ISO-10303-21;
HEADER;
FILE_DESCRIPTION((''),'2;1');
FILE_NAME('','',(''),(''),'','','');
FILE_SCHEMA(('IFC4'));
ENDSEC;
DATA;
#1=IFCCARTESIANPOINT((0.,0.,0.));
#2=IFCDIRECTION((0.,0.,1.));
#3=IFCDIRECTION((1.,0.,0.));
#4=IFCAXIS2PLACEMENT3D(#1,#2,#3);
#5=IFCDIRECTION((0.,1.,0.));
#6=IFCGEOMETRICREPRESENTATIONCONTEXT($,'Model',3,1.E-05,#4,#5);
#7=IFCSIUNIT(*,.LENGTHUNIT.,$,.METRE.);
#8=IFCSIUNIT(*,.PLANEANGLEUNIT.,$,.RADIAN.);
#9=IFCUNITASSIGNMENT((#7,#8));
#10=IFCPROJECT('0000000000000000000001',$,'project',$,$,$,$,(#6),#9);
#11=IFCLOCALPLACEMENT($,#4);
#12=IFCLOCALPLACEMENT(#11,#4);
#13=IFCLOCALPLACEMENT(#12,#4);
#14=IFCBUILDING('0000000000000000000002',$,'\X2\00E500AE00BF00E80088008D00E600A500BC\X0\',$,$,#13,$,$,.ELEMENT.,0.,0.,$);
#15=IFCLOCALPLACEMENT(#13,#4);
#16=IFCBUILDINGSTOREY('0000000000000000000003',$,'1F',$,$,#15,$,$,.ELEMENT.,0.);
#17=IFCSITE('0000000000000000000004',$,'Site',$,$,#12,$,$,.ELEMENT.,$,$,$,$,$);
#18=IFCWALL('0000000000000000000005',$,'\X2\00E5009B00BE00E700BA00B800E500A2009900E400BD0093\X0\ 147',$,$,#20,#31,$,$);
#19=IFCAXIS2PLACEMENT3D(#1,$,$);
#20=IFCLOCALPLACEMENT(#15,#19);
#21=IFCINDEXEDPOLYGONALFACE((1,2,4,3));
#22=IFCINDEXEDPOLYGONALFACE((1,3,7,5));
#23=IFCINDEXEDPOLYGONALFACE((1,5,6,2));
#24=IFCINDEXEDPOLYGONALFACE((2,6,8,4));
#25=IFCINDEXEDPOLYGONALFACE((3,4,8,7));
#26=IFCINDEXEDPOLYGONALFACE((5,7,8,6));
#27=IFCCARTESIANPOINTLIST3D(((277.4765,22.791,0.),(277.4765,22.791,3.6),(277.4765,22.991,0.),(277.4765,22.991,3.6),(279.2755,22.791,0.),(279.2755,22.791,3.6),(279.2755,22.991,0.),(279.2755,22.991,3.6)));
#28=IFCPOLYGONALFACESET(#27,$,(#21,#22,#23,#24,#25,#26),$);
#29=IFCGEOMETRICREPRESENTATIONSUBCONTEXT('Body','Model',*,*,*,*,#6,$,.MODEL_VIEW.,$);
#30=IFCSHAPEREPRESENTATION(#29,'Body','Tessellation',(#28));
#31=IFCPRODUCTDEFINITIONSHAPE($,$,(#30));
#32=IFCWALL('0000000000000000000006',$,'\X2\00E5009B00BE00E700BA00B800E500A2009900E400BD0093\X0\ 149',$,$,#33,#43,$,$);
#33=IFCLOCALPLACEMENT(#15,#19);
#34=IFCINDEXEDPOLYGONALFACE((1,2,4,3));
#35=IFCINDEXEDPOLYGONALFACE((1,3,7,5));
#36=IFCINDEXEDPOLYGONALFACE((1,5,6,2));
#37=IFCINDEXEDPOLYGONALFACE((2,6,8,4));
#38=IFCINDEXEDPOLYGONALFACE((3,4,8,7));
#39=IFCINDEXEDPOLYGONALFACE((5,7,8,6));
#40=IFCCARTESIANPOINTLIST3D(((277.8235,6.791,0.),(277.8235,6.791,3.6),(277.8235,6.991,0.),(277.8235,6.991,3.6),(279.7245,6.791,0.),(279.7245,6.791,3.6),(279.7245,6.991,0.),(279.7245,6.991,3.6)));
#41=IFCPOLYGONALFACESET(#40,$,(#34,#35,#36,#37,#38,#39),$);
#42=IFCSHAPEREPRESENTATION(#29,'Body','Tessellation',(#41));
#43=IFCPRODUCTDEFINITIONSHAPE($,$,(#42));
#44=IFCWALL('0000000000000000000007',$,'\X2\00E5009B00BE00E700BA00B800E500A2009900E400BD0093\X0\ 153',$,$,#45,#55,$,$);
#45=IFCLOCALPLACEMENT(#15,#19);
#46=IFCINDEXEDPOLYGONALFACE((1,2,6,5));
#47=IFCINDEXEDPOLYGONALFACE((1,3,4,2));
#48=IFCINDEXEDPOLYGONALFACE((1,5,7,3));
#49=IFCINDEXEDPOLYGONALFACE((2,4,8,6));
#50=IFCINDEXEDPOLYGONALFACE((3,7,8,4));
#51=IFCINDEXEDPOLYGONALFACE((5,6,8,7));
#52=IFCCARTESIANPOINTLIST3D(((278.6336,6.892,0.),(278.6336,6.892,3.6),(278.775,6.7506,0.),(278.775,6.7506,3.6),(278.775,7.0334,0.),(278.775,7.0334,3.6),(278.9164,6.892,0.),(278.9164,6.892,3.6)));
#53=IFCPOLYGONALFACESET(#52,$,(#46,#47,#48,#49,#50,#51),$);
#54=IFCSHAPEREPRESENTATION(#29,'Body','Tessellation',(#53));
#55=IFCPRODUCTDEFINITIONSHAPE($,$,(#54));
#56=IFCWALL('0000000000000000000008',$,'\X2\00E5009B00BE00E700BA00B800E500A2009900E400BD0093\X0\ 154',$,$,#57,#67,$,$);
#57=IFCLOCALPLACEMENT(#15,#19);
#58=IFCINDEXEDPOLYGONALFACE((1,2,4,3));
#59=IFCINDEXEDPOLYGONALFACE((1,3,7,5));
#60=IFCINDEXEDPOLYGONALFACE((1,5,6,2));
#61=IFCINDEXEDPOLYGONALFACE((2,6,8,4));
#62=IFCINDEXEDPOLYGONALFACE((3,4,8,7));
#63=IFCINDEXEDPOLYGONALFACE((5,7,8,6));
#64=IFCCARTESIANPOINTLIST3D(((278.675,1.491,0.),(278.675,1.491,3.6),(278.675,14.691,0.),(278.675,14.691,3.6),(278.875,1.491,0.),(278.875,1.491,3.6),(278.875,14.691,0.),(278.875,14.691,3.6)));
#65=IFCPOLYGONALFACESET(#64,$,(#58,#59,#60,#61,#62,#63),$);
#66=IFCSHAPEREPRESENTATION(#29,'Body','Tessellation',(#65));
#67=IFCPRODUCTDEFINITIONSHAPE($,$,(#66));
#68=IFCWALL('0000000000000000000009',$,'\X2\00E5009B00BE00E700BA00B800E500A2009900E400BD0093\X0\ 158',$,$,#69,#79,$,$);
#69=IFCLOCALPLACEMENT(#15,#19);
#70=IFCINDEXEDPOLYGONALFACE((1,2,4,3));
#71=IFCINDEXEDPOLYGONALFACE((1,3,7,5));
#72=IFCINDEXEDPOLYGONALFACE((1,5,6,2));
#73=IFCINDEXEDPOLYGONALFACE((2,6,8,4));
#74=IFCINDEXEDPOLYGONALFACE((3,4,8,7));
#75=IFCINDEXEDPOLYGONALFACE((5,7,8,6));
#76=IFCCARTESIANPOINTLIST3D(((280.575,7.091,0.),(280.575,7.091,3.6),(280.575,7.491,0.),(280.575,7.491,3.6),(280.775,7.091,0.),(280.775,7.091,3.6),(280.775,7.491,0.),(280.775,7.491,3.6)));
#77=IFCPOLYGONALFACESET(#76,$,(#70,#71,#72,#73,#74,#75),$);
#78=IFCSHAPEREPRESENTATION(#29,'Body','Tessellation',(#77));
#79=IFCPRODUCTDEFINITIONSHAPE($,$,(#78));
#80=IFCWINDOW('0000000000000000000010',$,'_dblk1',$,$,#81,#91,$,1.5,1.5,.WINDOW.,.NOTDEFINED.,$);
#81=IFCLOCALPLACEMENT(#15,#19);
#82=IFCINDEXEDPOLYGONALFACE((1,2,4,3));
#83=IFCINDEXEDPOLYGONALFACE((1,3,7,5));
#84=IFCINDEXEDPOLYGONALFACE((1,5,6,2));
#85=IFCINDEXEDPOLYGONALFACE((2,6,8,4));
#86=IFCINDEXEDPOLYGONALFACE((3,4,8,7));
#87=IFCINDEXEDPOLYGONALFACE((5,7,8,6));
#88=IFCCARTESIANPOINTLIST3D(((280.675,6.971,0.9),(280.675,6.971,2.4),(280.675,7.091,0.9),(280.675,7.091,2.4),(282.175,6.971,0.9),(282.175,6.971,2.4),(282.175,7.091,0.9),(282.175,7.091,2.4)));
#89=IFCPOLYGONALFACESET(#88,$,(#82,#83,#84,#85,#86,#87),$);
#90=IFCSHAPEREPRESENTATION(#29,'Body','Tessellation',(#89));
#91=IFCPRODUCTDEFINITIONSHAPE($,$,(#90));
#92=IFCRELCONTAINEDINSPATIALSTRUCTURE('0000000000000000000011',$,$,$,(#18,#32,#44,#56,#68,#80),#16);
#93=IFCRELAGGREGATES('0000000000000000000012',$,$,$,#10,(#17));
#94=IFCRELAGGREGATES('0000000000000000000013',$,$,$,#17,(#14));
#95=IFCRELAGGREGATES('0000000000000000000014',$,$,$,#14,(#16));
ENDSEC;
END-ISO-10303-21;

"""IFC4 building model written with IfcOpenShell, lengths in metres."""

from ifc_helpers import new_model, si_unit, direction, frame, frame_2d, origin_with_axes, place, context, subcontext, project, spatial, rectangle, extrude, element, save


model = new_model("IFC4")

# Units and contexts
model_context = context("Model", 3, precision=1e-05, world=origin_with_axes(), true_north=direction((0.0, 1.0, 0.0)))
body_context = subcontext(model_context, "Body", "Model", "MODEL_VIEW")
ifc_project = project(units=[si_unit("LENGTHUNIT", "METRE"), si_unit("PLANEANGLEUNIT", "RADIAN")], contexts=[model_context])

# Site, building, storey
placement = place(None, origin_with_axes())
site_placement = place(placement, origin_with_axes())
site = spatial("IfcSite", under=ifc_project, at=site_placement, Name="Site", CompositionType="ELEMENT")
building_placement = place(site_placement, origin_with_axes())
building = spatial("IfcBuilding", under=site, at=building_placement, Name="å®¿è\u0088\u008dæ¥¼", CompositionType="ELEMENT", ElevationOfRefHeight=0.0, ElevationOfTerrain=0.0)
storey_placement = place(building_placement, origin_with_axes())
storey = spatial("IfcBuildingStorey", under=building, at=storey_placement, Name="1F", CompositionType="ELEMENT", Elevation=0.0)

# Walls
wall_1_placement = place(storey_placement, frame((278.376, 22.891, 0.0), z_axis=(0.0, 0.0, 1.0), x_axis=(1.0, 0.0, 0.0)))
element("IfcWall", 1, at=wall_1_placement, inside=storey, Name="å\u009b¾çº¸å¢\u0099ä½\u0093 147", context=body_context, shape_type="SweptSolid", body=[
    extrude(rectangle(XDim=1.799, YDim=0.2, at=frame_2d((0.0, 0.0), x_axis=(1.0, 0.0, 0.0))), frame((0.0, 0.0, 0.0), z_axis=(0.0, 0.0, 1.0)), (0.0, 0.0, 1.0), 3.6),
])
wall_2_placement = place(storey_placement, frame((278.774, 6.891, 0.0), z_axis=(0.0, 0.0, 1.0), x_axis=(1.0, 0.0, 0.0)))
element("IfcWall", 2, at=wall_2_placement, inside=storey, Name="å\u009b¾çº¸å¢\u0099ä½\u0093 149", context=body_context, shape_type="SweptSolid", body=[
    extrude(rectangle(XDim=1.901, YDim=0.2, at=frame_2d((0.0, 0.0), x_axis=(1.0, 0.0, 0.0))), frame((0.0, 0.0, 0.0), z_axis=(0.0, 0.0, 1.0)), (0.0, 0.0, 1.0), 3.6),
])
wall_3_placement = place(storey_placement, frame((278.775, 6.892, 0.0), z_axis=(0.0, 0.0, 1.0), x_axis=(-0.707107, -0.707107, 0.0)))
element("IfcWall", 3, at=wall_3_placement, inside=storey, Name="å\u009b¾çº¸å¢\u0099ä½\u0093 153", context=body_context, shape_type="SweptSolid", body=[
    extrude(rectangle(XDim=0.2, YDim=0.2, at=frame_2d((0.0, 0.0), x_axis=(1.0, 0.0, 0.0))), frame((0.0, 0.0, 0.0), z_axis=(0.0, 0.0, 1.0)), (0.0, 0.0, 1.0), 3.6),
])
wall_4_placement = place(storey_placement, frame((278.775, 8.091, 0.0), z_axis=(0.0, 0.0, 1.0), x_axis=(0.0, 1.0, 0.0)))
element("IfcWall", 4, at=wall_4_placement, inside=storey, Name="å\u009b¾çº¸å¢\u0099ä½\u0093 154", context=body_context, shape_type="SweptSolid", body=[
    extrude(rectangle(XDim=13.2, YDim=0.2, at=frame_2d((0.0, 0.0), x_axis=(1.0, 0.0, 0.0))), frame((0.0, 0.0, 0.0), z_axis=(0.0, 0.0, 1.0)), (0.0, 0.0, 1.0), 3.6),
])
wall_5_placement = place(storey_placement, frame((280.675, 7.291, 0.0), z_axis=(0.0, 0.0, 1.0), x_axis=(0.0, -1.0, 0.0)))
element("IfcWall", 5, at=wall_5_placement, inside=storey, Name="å\u009b¾çº¸å¢\u0099ä½\u0093 158", context=body_context, shape_type="SweptSolid", body=[
    extrude(rectangle(XDim=0.4, YDim=0.2, at=frame_2d((0.0, 0.0), x_axis=(1.0, 0.0, 0.0))), frame((0.0, 0.0, 0.0), z_axis=(0.0, 0.0, 1.0)), (0.0, 0.0, 1.0), 3.6),
])

# Window
window_placement = place(storey_placement, frame((281.425, 7.031, 0.9), z_axis=(0.0, 0.0, 1.0), x_axis=(1.0, 0.0, 0.0)))
element("IfcWindow", 6, at=window_placement, inside=storey, Name="_dblk1", OverallHeight=1.5, OverallWidth=1.5, PartitioningType="NOTDEFINED", PredefinedType="WINDOW", context=body_context, shape_type="SweptSolid", body=[
    extrude(rectangle(XDim=1.5, YDim=0.12, at=frame_2d((0.0, 0.0), x_axis=(1.0, 0.0, 0.0))), frame((0.0, 0.0, 0.0), z_axis=(0.0, 0.0, 1.0)), (0.0, 0.0, 1.0), 1.5),
])

save(model, "model.ifc")
